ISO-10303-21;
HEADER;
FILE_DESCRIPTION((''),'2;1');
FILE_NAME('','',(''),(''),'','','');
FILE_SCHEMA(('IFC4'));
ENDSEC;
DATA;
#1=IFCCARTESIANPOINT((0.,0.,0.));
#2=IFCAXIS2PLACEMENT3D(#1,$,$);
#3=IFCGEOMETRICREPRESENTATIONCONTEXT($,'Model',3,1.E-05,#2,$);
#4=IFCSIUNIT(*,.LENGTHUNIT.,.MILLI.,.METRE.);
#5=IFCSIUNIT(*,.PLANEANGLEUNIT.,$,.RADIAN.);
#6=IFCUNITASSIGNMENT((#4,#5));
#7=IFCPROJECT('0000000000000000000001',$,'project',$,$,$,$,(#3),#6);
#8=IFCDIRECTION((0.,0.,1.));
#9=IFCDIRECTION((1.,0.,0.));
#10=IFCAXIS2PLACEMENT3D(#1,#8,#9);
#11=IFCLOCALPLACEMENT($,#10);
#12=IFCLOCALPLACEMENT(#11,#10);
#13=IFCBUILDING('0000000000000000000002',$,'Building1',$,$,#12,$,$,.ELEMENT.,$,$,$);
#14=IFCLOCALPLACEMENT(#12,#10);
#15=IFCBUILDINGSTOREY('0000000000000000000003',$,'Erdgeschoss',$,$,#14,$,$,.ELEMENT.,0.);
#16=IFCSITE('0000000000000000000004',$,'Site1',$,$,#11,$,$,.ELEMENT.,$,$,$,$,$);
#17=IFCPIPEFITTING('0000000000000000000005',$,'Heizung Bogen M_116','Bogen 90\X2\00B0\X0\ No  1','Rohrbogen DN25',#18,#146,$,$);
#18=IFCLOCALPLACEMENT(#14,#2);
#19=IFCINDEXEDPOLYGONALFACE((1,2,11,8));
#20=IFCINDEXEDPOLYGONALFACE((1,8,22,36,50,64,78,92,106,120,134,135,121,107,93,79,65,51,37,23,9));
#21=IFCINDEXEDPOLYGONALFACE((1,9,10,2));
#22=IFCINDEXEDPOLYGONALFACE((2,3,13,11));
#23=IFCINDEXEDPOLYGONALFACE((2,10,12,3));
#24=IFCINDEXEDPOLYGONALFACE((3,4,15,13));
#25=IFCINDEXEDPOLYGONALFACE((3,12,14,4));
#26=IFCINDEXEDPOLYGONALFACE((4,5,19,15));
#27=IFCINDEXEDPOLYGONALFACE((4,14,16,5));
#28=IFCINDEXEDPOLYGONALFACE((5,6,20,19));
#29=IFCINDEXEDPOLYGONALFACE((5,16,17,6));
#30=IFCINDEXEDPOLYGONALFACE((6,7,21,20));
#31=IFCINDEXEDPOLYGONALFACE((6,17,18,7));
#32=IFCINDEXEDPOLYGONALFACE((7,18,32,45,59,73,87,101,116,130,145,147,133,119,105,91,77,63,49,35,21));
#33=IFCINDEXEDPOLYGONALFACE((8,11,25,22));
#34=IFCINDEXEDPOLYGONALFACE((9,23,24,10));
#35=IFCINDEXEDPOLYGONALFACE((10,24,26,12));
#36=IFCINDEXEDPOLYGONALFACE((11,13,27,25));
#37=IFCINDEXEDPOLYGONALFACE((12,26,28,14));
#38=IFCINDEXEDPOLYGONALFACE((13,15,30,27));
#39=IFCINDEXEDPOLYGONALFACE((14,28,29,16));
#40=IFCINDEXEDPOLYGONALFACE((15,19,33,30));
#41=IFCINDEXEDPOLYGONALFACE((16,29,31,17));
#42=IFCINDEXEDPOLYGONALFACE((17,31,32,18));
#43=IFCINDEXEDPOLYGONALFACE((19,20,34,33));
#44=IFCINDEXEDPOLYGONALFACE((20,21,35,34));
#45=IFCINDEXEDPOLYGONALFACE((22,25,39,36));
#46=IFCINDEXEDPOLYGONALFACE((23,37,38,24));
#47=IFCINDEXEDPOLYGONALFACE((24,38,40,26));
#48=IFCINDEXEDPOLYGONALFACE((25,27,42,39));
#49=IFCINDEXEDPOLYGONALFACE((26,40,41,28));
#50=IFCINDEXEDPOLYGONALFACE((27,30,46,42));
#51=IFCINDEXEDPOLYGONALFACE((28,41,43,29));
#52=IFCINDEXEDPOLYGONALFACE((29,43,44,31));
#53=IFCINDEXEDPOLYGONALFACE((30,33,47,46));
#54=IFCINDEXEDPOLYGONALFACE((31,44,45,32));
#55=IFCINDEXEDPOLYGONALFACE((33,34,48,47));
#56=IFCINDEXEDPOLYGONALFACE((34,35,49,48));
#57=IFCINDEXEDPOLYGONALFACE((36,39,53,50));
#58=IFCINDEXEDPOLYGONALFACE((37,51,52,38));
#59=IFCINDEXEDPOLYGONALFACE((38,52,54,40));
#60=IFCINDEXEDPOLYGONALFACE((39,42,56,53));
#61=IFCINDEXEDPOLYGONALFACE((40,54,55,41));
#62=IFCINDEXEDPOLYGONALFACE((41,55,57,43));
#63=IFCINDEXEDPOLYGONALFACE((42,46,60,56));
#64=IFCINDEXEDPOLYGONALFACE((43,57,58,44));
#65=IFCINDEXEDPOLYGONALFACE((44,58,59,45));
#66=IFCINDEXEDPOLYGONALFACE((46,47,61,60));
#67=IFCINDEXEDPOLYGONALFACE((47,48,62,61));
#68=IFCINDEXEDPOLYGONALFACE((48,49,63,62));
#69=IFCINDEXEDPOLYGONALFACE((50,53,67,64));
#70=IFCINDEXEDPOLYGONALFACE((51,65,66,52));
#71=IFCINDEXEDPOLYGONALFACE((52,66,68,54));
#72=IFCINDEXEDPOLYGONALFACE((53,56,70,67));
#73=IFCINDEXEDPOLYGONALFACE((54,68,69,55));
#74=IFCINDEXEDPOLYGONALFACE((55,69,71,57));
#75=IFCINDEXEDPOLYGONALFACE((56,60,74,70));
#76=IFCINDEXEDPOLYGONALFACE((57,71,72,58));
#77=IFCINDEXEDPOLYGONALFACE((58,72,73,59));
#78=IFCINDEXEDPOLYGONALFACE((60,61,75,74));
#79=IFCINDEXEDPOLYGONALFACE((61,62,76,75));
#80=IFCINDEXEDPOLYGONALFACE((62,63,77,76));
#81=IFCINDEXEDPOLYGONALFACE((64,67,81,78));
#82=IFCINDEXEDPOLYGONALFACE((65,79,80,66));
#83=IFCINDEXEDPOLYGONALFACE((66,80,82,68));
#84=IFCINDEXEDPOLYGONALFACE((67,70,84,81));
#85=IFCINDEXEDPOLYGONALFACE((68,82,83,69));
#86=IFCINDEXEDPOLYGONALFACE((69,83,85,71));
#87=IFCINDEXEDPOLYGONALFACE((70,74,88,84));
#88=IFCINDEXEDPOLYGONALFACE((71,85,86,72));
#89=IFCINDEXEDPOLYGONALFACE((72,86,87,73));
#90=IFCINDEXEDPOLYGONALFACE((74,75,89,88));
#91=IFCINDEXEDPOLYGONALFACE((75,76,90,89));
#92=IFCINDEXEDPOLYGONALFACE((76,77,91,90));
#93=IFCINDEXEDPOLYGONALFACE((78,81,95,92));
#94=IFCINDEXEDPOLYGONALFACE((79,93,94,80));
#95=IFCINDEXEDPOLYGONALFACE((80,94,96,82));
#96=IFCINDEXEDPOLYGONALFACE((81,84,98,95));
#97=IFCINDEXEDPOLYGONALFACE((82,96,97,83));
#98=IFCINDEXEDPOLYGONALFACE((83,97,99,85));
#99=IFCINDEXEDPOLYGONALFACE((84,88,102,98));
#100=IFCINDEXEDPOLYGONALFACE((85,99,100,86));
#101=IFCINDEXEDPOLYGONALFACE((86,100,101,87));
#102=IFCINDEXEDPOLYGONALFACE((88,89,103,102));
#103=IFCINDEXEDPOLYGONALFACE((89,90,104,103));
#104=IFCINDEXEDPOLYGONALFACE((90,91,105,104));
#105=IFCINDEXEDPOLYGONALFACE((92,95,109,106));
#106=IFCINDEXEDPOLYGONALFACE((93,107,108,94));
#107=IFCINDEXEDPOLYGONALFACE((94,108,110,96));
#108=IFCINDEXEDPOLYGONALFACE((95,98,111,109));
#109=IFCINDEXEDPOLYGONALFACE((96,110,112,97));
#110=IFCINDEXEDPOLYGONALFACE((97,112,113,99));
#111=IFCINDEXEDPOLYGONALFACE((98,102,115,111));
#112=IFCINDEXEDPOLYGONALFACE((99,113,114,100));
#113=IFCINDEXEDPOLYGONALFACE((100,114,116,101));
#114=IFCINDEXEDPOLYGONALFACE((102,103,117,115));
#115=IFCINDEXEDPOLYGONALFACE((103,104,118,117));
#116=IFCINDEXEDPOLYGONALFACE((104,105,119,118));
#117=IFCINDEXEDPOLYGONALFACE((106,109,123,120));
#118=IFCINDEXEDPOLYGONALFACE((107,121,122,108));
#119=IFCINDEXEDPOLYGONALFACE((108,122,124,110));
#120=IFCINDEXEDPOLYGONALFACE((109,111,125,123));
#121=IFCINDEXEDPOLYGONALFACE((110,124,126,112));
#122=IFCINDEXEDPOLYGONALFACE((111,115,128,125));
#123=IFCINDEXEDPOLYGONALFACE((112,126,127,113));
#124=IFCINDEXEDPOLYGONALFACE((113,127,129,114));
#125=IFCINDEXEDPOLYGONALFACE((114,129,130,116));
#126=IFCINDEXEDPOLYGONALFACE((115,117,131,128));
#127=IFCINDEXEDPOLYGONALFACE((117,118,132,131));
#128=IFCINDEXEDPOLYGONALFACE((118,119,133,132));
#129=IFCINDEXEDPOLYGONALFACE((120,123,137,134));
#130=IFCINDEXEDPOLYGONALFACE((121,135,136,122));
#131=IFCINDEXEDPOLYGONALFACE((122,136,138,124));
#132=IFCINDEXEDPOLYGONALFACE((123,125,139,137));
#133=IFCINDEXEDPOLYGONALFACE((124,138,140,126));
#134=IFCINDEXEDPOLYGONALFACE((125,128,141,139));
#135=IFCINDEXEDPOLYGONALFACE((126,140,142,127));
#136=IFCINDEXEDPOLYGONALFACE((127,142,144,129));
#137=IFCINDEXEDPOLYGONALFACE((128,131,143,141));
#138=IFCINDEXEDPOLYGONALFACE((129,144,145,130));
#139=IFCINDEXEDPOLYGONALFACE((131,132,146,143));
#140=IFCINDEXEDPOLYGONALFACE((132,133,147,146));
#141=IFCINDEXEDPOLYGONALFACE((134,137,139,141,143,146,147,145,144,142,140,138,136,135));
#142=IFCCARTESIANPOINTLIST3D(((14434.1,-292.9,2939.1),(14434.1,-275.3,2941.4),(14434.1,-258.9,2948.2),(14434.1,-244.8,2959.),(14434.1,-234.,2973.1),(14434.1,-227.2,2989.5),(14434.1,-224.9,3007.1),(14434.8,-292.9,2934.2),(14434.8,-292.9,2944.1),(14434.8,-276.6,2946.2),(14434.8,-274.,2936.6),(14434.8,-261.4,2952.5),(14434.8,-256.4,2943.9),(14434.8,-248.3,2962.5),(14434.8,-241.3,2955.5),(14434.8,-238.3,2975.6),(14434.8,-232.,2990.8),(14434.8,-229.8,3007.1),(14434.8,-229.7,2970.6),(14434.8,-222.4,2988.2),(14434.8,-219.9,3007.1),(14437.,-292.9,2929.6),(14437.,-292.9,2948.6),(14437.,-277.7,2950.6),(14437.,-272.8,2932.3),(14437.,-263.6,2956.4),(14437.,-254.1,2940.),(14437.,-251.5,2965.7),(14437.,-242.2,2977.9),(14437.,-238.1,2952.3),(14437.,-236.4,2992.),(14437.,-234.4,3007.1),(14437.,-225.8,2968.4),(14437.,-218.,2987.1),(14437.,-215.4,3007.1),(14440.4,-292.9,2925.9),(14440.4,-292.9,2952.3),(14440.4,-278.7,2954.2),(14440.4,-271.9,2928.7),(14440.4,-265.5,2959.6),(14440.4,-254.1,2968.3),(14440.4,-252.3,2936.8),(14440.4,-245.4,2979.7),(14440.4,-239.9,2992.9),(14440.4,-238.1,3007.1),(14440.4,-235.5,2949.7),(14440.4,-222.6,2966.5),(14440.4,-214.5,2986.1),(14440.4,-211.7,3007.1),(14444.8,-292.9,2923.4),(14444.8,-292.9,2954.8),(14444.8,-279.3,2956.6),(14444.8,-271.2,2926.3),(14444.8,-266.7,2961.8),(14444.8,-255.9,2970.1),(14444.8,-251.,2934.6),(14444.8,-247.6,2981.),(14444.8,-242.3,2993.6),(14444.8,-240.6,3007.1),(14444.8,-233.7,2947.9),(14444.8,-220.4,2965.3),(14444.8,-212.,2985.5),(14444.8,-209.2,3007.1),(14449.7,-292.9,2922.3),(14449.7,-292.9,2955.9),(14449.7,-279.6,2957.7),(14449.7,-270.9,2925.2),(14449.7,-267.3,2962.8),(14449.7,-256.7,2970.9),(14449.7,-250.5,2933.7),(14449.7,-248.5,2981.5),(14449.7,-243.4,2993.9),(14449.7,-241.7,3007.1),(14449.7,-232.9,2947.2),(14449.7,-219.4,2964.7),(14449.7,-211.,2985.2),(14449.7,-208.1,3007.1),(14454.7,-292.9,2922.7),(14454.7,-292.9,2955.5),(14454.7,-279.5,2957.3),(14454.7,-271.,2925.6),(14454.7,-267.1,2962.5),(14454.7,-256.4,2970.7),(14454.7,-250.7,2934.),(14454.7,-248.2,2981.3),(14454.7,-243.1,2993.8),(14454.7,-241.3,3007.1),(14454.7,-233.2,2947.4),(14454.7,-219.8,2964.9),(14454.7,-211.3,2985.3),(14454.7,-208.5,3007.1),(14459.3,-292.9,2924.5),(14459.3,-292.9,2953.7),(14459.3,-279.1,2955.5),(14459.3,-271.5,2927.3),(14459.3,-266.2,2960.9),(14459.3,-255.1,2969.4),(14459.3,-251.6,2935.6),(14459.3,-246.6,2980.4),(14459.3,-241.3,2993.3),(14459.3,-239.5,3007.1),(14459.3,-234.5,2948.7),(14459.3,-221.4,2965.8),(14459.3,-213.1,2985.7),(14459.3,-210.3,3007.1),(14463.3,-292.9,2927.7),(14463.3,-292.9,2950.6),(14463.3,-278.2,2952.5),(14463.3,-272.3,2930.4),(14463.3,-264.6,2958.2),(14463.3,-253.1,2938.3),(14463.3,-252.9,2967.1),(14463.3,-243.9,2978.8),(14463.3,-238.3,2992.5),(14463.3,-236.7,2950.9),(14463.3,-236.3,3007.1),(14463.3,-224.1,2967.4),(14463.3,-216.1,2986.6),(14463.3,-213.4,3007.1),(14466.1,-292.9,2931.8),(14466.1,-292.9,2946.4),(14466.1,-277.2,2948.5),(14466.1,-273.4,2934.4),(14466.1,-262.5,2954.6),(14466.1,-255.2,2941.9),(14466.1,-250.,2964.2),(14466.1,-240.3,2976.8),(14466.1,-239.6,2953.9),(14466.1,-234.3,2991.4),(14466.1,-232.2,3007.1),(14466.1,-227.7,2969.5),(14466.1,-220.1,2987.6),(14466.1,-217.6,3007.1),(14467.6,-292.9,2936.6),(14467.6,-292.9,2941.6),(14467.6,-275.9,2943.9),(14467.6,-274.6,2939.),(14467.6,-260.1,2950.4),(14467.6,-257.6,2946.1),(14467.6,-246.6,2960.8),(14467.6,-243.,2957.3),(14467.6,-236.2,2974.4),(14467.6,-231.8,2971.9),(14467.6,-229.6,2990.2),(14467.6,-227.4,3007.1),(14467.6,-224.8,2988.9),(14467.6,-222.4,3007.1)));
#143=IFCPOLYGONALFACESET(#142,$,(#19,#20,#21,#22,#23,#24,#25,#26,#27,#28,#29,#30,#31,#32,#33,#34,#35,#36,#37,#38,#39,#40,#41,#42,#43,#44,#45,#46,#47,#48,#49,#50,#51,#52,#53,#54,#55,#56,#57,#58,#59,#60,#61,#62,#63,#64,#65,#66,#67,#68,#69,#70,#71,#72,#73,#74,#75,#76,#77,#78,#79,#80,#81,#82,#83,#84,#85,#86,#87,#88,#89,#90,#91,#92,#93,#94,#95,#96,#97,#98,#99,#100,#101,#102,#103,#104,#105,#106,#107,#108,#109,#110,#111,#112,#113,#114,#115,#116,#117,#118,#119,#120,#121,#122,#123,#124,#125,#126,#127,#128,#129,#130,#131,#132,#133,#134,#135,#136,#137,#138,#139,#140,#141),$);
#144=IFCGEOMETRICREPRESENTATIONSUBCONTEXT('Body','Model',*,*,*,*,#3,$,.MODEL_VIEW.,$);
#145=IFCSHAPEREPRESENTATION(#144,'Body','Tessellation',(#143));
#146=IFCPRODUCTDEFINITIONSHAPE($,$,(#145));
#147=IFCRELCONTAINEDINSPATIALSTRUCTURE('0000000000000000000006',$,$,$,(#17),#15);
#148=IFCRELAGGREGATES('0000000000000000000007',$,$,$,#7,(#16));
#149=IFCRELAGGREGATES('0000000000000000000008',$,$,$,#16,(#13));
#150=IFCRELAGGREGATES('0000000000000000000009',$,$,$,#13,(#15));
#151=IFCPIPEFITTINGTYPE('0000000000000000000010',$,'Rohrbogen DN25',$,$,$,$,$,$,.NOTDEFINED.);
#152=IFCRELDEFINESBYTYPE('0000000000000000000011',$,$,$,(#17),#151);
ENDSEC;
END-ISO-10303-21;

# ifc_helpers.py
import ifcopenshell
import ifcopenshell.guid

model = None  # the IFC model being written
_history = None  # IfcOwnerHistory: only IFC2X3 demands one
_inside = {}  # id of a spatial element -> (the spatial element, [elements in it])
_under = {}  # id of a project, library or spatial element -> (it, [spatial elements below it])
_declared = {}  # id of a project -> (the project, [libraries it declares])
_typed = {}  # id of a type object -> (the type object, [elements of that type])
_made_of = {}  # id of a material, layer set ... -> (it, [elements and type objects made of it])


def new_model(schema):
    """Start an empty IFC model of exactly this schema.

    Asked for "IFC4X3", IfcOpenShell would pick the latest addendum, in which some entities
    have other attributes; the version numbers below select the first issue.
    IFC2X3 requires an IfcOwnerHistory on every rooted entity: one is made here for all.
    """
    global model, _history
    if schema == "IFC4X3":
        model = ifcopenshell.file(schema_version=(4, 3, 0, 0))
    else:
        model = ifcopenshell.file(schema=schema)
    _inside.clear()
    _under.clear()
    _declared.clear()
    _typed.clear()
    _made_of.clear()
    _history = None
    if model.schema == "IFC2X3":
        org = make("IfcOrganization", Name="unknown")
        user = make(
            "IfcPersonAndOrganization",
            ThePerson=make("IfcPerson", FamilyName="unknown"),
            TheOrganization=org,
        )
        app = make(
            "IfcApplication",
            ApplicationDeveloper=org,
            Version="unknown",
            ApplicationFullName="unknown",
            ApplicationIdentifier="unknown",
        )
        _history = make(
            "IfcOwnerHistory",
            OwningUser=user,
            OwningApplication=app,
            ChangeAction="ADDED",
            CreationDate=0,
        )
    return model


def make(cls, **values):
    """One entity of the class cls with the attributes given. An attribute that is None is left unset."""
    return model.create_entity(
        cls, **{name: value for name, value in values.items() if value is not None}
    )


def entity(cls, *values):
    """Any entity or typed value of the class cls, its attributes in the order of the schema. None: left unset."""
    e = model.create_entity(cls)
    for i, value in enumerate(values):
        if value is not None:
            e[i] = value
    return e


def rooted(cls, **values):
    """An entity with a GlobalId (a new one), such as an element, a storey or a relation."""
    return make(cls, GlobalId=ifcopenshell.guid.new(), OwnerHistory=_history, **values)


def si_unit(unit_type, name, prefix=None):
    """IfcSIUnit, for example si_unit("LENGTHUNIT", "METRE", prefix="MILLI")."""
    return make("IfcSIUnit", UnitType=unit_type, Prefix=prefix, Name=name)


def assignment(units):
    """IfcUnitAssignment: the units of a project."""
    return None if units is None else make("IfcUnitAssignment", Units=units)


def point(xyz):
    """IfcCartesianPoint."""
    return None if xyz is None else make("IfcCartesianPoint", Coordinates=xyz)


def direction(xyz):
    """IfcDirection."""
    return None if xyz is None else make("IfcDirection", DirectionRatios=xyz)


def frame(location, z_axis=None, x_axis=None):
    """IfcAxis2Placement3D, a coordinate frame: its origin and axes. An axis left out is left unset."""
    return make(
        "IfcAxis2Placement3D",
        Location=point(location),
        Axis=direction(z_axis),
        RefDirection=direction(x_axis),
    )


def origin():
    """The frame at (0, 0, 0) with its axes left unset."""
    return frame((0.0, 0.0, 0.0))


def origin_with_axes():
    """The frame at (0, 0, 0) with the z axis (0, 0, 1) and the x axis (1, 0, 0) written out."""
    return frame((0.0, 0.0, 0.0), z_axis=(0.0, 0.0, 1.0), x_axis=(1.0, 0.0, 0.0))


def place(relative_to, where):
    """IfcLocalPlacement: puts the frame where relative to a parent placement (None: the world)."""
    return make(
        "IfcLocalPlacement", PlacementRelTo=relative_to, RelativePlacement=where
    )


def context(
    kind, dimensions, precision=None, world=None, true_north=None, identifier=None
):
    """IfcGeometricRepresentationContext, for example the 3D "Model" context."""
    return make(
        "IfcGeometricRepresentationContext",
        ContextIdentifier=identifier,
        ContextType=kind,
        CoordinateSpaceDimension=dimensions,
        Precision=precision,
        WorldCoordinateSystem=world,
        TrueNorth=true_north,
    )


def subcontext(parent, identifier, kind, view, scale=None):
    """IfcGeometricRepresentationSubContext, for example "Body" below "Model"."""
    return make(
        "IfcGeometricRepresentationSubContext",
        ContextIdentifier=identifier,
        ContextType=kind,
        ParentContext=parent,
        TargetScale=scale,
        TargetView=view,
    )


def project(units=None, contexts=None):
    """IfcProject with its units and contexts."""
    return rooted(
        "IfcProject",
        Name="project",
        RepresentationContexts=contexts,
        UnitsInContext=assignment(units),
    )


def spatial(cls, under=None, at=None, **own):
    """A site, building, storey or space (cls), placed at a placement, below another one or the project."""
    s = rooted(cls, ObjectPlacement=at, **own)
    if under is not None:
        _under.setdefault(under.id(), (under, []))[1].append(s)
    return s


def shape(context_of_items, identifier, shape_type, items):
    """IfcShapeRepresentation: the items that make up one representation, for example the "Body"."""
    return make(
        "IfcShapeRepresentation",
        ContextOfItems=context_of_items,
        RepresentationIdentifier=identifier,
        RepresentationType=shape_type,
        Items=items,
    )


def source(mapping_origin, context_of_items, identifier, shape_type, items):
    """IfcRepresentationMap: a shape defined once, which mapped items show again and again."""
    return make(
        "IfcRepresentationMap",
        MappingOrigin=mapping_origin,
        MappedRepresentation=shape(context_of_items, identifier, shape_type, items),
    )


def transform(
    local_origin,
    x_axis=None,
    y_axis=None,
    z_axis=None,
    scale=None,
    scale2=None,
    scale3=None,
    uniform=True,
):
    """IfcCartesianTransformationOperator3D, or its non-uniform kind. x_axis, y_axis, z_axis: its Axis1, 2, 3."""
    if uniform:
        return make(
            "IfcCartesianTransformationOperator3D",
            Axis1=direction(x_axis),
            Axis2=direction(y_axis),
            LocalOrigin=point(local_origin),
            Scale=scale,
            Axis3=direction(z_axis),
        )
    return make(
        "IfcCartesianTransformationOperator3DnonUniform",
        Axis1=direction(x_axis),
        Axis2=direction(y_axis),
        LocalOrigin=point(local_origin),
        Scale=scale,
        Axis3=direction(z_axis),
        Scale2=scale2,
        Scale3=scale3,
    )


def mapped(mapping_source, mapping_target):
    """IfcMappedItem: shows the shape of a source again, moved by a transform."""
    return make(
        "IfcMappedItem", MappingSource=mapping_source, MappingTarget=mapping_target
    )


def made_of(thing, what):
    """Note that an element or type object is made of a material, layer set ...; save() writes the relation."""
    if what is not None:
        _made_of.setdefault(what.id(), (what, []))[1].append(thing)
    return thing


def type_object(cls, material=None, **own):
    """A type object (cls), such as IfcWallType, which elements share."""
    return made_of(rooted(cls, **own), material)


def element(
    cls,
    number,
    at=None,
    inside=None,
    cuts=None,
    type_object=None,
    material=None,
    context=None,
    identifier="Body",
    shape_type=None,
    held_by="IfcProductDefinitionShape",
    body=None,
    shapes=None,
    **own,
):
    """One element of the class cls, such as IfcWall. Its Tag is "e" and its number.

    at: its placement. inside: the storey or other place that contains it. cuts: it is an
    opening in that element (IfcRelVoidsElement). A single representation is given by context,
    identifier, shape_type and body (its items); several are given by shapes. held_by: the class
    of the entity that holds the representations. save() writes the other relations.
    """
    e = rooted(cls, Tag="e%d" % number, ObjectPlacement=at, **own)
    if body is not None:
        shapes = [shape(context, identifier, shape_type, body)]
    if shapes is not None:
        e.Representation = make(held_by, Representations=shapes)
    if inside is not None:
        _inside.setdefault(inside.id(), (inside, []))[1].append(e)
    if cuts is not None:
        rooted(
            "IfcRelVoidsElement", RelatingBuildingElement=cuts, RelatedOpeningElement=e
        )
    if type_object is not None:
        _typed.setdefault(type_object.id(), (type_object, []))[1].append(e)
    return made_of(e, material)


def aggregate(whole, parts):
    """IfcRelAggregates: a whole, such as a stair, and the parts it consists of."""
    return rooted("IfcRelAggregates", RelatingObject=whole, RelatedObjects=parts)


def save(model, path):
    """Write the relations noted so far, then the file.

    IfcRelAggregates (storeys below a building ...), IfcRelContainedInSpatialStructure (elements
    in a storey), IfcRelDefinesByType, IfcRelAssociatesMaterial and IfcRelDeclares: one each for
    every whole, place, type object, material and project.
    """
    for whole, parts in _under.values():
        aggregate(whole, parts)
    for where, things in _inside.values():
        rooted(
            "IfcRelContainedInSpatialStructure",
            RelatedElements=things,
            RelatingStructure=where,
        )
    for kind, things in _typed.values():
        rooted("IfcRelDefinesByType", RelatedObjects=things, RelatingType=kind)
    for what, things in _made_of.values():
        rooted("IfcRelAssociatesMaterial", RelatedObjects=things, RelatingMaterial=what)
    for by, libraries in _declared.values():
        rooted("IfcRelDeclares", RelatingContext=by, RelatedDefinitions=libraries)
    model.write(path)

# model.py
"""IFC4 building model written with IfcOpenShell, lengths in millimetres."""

from ifc_helpers import new_model, entity, si_unit, frame, origin, origin_with_axes, place, context, subcontext, project, spatial, source, transform, mapped, type_object, element, save


model = new_model("IFC4")

# Units and contexts
model_context = context("Model", 3, precision=1e-05, world=origin())
body_context = subcontext(model_context, "Body", "Model", "MODEL_VIEW")
ifc_project = project(units=[si_unit("LENGTHUNIT", "METRE", prefix="MILLI"), si_unit("PLANEANGLEUNIT", "RADIAN")], contexts=[model_context])

# Site, building, storey
site_placement = place(None, origin_with_axes())
site = spatial("IfcSite", under=ifc_project, at=site_placement, Name="Site1", CompositionType="ELEMENT")
building_placement = place(site_placement, origin_with_axes())
building = spatial("IfcBuilding", under=site, at=building_placement, Name="Building1", CompositionType="ELEMENT")
storey_placement = place(building_placement, origin_with_axes())
storey = spatial("IfcBuildingStorey", under=building, at=storey_placement, Name="Erdgeschoss", CompositionType="ELEMENT", Elevation=0.0)

# Pipe fitting
pipe_fitting_type = type_object("IfcPipeFittingType", Name="Rohrbogen DN25", PredefinedType="NOTDEFINED")
shared_shape_1 = source(origin_with_axes(), body_context, "Body", "SolidModel", [
    entity("IfcRevolvedAreaSolid", entity("IfcCircleProfileDef", "AREA", None, entity("IfcAxis2Placement2D", entity("IfcCartesianPoint", [0.0, 0.0]), entity("IfcDirection", [1.0, 0.0])), 16.9), entity("IfcAxis2Placement3D", entity("IfcCartesianPoint", [-42.4, 0.0, -25.6]), entity("IfcDirection", [1.0, 0.0, 0.0]), entity("IfcDirection", [0.0, 1.0, 0.0])), entity("IfcAxis1Placement", entity("IfcCartesianPoint", [0.0, 68.0, 0.0]), entity("IfcDirection", [-1.0, 0.0, 0.0])), 1.570796),
])
pipe_fitting_1_placement = place(storey_placement, frame((14450.9, -250.5, 2964.7), z_axis=(0.0, 0.0, 1.0), x_axis=(1.0, 0.0, 0.0)))
element("IfcPipeFitting", 1, at=pipe_fitting_1_placement, inside=storey, type_object=pipe_fitting_type, Name="Heizung Bogen M_116", Description="Bogen 90° No  1", ObjectType="Rohrbogen DN25", context=body_context, shape_type="MappedRepresentation", body=[
    mapped(shared_shape_1, transform((0.0, 0.0, 0.0), x_axis=(0.0, 1.0, 0.0), y_axis=(-1.0, 0.0, 0.0), z_axis=(0.0, 0.0, 1.0), scale=1.0)),
])

save(model, "model.ifc")
